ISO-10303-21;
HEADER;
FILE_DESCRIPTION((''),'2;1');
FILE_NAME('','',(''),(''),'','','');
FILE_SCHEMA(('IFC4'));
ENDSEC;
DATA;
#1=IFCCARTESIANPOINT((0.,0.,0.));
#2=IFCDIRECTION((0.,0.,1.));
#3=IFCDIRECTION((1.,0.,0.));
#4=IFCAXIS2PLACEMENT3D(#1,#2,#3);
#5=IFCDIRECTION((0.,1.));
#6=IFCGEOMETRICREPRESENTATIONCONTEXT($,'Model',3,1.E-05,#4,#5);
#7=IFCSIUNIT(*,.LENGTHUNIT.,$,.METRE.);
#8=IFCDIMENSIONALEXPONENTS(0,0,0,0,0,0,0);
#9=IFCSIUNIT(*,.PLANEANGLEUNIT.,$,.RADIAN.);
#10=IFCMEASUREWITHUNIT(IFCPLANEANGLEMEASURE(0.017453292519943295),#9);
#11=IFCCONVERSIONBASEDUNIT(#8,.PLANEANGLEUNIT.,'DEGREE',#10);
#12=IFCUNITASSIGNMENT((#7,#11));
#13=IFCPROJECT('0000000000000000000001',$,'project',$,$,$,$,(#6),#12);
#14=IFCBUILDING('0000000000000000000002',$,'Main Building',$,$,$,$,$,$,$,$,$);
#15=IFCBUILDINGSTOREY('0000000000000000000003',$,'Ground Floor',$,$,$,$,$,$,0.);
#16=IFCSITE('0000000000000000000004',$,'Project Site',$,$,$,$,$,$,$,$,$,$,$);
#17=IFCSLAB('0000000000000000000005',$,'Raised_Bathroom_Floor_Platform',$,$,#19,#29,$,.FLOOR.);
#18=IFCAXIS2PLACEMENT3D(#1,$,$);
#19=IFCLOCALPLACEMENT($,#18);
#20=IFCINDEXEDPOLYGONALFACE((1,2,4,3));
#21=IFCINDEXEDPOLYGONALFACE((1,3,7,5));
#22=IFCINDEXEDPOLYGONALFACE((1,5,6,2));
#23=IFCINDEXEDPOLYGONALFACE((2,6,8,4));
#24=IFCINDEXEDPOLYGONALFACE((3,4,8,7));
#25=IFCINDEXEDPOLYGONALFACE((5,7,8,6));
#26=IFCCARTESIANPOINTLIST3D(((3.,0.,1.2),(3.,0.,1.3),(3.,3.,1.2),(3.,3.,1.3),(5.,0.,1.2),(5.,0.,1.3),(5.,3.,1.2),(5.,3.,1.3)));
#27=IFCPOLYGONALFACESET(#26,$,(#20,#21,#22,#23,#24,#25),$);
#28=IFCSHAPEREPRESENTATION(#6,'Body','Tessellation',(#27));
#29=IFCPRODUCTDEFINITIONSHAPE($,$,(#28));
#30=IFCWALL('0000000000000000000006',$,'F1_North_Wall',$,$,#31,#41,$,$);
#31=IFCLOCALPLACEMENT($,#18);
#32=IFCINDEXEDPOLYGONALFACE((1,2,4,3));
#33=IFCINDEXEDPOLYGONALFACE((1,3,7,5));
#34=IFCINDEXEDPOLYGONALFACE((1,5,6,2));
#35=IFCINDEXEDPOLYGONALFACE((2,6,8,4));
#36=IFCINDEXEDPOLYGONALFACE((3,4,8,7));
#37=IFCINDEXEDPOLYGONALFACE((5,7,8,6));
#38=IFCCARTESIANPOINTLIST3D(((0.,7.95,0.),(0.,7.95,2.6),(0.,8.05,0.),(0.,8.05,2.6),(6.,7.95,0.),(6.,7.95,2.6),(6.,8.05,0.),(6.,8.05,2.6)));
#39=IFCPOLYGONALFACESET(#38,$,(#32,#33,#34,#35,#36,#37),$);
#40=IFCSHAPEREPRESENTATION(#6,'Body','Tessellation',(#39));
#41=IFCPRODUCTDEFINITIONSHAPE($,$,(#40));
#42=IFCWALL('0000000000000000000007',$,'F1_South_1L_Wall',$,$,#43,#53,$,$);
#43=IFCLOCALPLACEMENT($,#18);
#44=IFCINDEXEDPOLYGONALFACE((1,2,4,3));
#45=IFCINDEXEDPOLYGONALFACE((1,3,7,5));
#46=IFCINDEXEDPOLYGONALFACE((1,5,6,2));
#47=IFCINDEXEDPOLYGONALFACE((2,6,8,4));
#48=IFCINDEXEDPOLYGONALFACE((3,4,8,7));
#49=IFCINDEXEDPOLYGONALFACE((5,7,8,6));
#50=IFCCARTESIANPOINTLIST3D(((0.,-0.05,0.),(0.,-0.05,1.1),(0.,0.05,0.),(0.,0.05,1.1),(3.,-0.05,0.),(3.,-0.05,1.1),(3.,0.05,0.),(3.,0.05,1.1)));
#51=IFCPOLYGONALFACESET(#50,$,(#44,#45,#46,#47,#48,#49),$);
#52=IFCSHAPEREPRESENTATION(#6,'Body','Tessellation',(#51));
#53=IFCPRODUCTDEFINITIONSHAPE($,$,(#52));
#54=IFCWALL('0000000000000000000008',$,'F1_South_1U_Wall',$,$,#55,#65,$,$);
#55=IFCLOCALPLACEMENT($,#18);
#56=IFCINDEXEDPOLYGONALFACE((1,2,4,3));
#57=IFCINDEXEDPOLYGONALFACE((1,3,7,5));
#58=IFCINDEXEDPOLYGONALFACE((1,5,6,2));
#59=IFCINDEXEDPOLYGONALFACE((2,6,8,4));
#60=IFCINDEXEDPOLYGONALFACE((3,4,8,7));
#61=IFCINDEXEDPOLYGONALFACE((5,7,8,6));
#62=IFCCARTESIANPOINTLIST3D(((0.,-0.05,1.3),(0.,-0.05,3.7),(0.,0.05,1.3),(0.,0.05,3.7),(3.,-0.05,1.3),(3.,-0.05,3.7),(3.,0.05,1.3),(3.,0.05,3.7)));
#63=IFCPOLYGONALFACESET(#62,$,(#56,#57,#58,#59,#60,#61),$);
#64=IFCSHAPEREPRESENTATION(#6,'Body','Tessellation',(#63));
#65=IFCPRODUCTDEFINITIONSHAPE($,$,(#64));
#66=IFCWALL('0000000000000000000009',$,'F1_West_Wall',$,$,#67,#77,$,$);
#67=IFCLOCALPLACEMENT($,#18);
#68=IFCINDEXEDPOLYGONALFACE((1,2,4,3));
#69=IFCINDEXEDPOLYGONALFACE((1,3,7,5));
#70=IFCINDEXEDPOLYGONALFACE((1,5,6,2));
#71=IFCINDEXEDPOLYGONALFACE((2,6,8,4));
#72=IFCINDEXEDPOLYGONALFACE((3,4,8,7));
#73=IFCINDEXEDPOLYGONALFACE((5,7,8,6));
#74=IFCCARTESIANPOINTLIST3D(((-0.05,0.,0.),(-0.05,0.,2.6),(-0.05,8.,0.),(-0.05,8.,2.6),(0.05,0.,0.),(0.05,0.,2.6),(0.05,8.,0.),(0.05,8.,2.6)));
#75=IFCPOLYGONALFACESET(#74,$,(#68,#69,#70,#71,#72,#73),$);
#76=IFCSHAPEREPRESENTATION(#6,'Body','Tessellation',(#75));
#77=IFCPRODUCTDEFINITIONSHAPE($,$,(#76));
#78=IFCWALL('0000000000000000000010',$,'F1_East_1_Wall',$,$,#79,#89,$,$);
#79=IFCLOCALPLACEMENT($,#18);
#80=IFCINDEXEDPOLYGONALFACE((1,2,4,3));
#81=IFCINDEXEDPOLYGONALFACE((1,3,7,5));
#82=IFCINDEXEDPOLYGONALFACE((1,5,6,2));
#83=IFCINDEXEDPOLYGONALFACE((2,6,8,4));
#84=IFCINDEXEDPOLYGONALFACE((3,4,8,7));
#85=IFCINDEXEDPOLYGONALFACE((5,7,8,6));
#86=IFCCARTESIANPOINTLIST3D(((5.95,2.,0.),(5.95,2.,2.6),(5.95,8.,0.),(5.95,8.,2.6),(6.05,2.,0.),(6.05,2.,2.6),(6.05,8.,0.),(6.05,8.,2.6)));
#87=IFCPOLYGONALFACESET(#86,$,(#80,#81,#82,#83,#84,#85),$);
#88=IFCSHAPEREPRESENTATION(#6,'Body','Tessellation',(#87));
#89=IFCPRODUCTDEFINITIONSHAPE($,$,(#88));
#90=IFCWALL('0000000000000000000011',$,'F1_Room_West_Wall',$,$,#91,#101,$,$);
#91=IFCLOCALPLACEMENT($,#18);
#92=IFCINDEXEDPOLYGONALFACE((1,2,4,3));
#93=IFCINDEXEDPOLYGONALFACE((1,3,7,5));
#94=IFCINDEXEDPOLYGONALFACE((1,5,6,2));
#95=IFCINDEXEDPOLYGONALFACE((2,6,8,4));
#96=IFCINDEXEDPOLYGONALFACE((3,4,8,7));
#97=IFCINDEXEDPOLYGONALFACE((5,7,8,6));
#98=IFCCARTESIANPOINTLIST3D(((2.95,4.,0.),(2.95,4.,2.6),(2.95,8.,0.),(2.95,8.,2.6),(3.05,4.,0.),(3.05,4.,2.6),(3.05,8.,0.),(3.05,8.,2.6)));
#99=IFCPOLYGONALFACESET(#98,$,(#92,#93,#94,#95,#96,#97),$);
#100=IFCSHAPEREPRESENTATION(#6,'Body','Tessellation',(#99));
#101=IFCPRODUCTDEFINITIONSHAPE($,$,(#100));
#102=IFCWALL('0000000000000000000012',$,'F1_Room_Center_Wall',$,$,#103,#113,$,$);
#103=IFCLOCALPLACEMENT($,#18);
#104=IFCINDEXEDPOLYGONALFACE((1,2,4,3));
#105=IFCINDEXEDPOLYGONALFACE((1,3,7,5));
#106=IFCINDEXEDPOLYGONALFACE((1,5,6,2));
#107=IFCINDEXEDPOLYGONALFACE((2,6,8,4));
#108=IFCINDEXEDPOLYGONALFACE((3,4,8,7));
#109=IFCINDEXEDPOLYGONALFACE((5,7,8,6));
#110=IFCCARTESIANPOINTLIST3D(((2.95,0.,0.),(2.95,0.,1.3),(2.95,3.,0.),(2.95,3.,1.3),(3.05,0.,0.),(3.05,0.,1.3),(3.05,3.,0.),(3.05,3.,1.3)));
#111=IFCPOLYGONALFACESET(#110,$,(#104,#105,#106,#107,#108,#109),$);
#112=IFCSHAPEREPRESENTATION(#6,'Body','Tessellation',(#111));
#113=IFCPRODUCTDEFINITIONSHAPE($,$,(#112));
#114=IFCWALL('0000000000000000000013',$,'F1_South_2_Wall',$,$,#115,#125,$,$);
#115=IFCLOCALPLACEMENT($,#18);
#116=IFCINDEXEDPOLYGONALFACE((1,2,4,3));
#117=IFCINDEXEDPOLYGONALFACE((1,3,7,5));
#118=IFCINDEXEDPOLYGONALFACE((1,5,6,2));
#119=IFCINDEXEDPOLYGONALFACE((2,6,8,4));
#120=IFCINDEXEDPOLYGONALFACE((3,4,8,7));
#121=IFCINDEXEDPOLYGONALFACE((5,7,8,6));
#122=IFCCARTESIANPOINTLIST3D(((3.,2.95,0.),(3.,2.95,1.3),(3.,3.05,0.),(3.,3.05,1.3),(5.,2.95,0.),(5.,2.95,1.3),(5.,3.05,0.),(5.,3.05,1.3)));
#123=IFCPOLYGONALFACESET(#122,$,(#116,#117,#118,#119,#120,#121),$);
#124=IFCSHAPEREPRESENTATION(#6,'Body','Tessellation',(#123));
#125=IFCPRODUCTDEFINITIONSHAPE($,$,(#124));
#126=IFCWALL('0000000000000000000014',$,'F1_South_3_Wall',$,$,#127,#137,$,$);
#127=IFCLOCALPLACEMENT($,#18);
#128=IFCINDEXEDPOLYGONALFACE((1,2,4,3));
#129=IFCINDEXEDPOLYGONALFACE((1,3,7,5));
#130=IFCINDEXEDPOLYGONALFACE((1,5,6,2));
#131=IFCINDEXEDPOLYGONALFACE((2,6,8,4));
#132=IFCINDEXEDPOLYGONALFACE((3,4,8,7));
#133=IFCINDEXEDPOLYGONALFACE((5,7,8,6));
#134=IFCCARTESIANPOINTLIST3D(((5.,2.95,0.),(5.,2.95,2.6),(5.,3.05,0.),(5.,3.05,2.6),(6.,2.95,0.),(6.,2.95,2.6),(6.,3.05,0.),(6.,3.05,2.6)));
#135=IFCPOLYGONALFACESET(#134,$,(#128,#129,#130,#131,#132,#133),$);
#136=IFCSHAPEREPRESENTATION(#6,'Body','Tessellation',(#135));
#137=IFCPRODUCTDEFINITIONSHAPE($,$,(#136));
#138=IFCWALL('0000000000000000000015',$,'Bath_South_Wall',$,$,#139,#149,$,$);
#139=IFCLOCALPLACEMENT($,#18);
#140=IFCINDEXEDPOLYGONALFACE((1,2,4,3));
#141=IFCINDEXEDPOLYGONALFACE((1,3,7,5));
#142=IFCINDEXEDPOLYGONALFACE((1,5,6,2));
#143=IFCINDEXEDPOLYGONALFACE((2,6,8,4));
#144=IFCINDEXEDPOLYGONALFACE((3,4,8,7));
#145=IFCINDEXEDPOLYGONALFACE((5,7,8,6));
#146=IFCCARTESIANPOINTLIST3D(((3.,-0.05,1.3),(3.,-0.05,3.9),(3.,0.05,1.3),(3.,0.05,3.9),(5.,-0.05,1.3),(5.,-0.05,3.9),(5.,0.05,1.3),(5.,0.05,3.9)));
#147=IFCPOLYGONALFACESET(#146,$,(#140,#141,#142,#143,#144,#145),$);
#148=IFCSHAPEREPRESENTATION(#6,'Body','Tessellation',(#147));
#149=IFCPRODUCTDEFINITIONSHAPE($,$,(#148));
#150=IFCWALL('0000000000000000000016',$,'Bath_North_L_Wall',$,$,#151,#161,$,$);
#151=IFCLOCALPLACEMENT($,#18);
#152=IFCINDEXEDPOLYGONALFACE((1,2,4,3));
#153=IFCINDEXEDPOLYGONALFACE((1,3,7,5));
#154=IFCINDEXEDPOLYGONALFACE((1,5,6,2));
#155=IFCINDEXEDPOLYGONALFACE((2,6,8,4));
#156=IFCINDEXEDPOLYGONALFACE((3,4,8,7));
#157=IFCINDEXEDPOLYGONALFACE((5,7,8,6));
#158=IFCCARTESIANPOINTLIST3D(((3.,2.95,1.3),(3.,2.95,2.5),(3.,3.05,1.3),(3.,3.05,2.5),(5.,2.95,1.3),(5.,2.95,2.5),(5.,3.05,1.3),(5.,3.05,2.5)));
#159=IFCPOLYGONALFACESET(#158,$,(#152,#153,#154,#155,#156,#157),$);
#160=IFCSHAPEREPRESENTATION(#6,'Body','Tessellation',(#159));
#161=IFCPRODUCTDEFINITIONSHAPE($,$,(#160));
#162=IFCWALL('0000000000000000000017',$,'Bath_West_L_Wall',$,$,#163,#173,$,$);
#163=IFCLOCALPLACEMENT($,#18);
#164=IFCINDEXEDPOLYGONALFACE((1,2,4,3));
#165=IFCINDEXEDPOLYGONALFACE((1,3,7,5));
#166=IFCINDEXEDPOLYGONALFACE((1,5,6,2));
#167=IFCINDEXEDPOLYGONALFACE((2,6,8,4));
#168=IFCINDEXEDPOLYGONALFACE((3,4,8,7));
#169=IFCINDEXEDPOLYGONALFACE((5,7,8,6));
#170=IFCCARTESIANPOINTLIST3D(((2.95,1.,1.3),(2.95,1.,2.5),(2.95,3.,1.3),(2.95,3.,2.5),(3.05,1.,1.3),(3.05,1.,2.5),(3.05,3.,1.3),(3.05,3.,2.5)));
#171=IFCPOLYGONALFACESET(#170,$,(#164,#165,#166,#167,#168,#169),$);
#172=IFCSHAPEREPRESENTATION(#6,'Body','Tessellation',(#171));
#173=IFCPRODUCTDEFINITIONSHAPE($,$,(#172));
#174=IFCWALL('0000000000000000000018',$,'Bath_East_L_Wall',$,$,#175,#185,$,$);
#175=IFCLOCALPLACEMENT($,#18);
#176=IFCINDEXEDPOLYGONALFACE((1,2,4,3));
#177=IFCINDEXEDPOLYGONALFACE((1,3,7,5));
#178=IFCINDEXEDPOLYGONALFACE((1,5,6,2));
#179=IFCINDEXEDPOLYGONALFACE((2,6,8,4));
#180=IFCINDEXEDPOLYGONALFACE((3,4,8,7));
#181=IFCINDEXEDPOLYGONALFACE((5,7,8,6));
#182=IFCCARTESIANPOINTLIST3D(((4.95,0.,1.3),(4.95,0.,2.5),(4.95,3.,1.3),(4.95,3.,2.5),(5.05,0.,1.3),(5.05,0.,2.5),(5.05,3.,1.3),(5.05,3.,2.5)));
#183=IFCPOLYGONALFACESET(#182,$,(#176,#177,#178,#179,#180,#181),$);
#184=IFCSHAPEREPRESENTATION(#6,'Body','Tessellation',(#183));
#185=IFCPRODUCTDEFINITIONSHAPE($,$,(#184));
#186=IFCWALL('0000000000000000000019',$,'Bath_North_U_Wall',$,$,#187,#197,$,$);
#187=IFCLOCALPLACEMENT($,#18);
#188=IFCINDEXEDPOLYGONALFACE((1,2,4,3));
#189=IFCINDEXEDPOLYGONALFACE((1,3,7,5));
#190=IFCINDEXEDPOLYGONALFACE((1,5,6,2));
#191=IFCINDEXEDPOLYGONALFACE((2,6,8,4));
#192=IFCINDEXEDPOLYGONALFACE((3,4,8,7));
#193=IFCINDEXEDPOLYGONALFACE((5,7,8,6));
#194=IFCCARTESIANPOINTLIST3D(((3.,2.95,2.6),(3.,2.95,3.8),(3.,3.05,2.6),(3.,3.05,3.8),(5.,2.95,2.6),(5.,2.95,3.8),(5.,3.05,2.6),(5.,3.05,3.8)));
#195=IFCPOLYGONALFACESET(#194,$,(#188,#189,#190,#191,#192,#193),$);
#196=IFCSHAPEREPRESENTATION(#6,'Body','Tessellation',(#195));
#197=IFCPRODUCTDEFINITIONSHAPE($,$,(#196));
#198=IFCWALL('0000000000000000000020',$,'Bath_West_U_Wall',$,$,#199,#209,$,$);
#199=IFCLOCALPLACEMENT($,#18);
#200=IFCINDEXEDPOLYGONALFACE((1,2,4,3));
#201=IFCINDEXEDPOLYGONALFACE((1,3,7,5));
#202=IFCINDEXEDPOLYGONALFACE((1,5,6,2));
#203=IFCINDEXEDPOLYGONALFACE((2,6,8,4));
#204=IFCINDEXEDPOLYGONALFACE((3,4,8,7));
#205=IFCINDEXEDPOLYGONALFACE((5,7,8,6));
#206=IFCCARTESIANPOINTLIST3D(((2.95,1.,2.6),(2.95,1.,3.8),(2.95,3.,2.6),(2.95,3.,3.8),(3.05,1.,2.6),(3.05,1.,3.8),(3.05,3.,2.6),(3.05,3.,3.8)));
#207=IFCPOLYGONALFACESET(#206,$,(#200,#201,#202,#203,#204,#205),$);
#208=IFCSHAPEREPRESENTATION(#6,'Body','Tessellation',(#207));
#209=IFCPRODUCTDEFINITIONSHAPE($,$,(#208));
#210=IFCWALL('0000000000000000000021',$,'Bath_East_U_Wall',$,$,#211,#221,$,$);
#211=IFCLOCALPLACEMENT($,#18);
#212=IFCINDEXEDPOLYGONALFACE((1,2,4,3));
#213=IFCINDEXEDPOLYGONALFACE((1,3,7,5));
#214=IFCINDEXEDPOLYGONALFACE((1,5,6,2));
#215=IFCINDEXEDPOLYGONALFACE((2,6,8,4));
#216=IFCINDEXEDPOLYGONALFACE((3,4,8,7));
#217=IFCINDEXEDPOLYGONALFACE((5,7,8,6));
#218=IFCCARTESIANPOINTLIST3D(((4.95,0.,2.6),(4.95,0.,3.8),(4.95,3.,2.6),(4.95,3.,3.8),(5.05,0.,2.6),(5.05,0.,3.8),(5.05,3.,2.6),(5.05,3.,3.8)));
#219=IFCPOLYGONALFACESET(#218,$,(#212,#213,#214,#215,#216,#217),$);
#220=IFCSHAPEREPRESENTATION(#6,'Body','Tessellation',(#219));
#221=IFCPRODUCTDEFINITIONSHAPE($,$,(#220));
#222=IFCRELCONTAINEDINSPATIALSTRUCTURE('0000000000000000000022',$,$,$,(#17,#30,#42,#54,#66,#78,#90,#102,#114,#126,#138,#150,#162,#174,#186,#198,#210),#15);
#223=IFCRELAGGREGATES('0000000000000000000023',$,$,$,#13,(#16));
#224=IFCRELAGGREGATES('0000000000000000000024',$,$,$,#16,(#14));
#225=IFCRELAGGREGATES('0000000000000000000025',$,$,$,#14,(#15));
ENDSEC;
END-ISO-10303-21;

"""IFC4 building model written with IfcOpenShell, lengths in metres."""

from ifc_helpers import new_model, entity, si_unit, converted_unit, direction, frame, frame_2d, origin, origin_with_axes, place, context, project, spatial, polyline, rectangle, outline, extrude, element, save


model = new_model("IFC4")

# Units and contexts
model_context = context("Model", 3, precision=1e-05, world=origin_with_axes(), true_north=direction((0.0, 1.0)))
ifc_project = project(units=[si_unit("LENGTHUNIT", "METRE"), converted_unit("PLANEANGLEUNIT", "DEGREE", entity("IfcPlaneAngleMeasure", 0.017453292519943295), si_unit("PLANEANGLEUNIT", "RADIAN"), dimensions=[0, 0, 0, 0, 0, 0, 0])], contexts=[model_context])

# Site, building, storey
site = spatial("IfcSite", under=ifc_project, Name="Project Site")
building = spatial("IfcBuilding", under=site, Name="Main Building")
storey = spatial("IfcBuildingStorey", under=building, Name="Ground Floor", Elevation=0.0)

# Slab
slab_1_placement = place(None, frame((0.0, 0.0, 1.2), z_axis=(0.0, 0.0, 1.0), x_axis=(1.0, 0.0, 0.0)))
element("IfcSlab", 1, at=slab_1_placement, inside=storey, Name="Raised_Bathroom_Floor_Platform", PredefinedType="FLOOR", context=model_context, shape_type="SweptSolid", body=[
    extrude(outline(polyline([(3.0, 0.0), (5.0, 0.0), (5.0, 3.0), (3.0, 3.0), (3.0, 0.0)])), origin(), (0.0, 0.0, 1.0), 0.1),
])

# Walls
wall_1_placement = place(None, frame((0.0, 8.0, 0.0), z_axis=(0.0, 0.0, 1.0), x_axis=(1.0, 0.0, 0.0)))
element("IfcWall", 2, at=wall_1_placement, inside=storey, Name="F1_North_Wall", context=model_context, shape_type="SweptSolid", body=[
    extrude(rectangle(XDim=6.0, YDim=0.1, at=frame_2d((3.0, 0.0))), origin(), (0.0, 0.0, 1.0), 2.6),
])
wall_2_placement = place(None, origin_with_axes())
element("IfcWall", 3, at=wall_2_placement, inside=storey, Name="F1_South_1L_Wall", context=model_context, shape_type="SweptSolid", body=[
    extrude(rectangle(XDim=3.0, YDim=0.1, at=frame_2d((1.5, 0.0))), origin(), (0.0, 0.0, 1.0), 1.1),
])
wall_3_placement = place(None, frame((0.0, 0.0, 1.3), z_axis=(0.0, 0.0, 1.0), x_axis=(1.0, 0.0, 0.0)))
element("IfcWall", 4, at=wall_3_placement, inside=storey, Name="F1_South_1U_Wall", context=model_context, shape_type="SweptSolid", body=[
    extrude(rectangle(XDim=3.0, YDim=0.1, at=frame_2d((1.5, 0.0))), origin(), (0.0, 0.0, 1.0), 2.4),
])
wall_4_placement = place(None, frame((0.0, 0.0, 0.0), z_axis=(0.0, 0.0, 1.0), x_axis=(0.0, 1.0, 0.0)))
element("IfcWall", 5, at=wall_4_placement, inside=storey, Name="F1_West_Wall", context=model_context, shape_type="SweptSolid", body=[
    extrude(rectangle(XDim=8.0, YDim=0.1, at=frame_2d((4.0, 0.0))), origin(), (0.0, 0.0, 1.0), 2.6),
])
wall_5_placement = place(None, frame((6.0, 2.0, 0.0), z_axis=(0.0, 0.0, 1.0), x_axis=(0.0, 1.0, 0.0)))
element("IfcWall", 6, at=wall_5_placement, inside=storey, Name="F1_East_1_Wall", context=model_context, shape_type="SweptSolid", body=[
    extrude(rectangle(XDim=6.0, YDim=0.1, at=frame_2d((3.0, 0.0))), origin(), (0.0, 0.0, 1.0), 2.6),
])
wall_6_placement = place(None, frame((3.0, 4.0, 0.0), z_axis=(0.0, 0.0, 1.0), x_axis=(0.0, 1.0, 0.0)))
element("IfcWall", 7, at=wall_6_placement, inside=storey, Name="F1_Room_West_Wall", context=model_context, shape_type="SweptSolid", body=[
    extrude(rectangle(XDim=4.0, YDim=0.1, at=frame_2d((2.0, 0.0))), origin(), (0.0, 0.0, 1.0), 2.6),
])
wall_7_placement = place(None, frame((3.0, 0.0, 0.0), z_axis=(0.0, 0.0, 1.0), x_axis=(0.0, 1.0, 0.0)))
element("IfcWall", 8, at=wall_7_placement, inside=storey, Name="F1_Room_Center_Wall", context=model_context, shape_type="SweptSolid", body=[
    extrude(rectangle(XDim=3.0, YDim=0.1, at=frame_2d((1.5, 0.0))), origin(), (0.0, 0.0, 1.0), 1.3),
])
wall_8_placement = place(None, frame((3.0, 3.0, 0.0), z_axis=(0.0, 0.0, 1.0), x_axis=(1.0, 0.0, 0.0)))
element("IfcWall", 9, at=wall_8_placement, inside=storey, Name="F1_South_2_Wall", context=model_context, shape_type="SweptSolid", body=[
    extrude(rectangle(XDim=2.0, YDim=0.1, at=frame_2d((1.0, 0.0))), origin(), (0.0, 0.0, 1.0), 1.3),
])
wall_9_placement = place(None, frame((5.0, 3.0, 0.0), z_axis=(0.0, 0.0, 1.0), x_axis=(1.0, 0.0, 0.0)))
element("IfcWall", 10, at=wall_9_placement, inside=storey, Name="F1_South_3_Wall", context=model_context, shape_type="SweptSolid", body=[
    extrude(rectangle(XDim=1.0, YDim=0.1, at=frame_2d((0.5, 0.0))), origin(), (0.0, 0.0, 1.0), 2.6),
])
wall_10_placement = place(None, frame((3.0, 0.0, 1.3), z_axis=(0.0, 0.0, 1.0), x_axis=(1.0, 0.0, 0.0)))
element("IfcWall", 11, at=wall_10_placement, inside=storey, Name="Bath_South_Wall", context=model_context, shape_type="SweptSolid", body=[
    extrude(rectangle(XDim=2.0, YDim=0.1, at=frame_2d((1.0, 0.0))), origin(), (0.0, 0.0, 1.0), 2.6),
])
for number, where, z_axis, x_axis, name in (
    (12, (3.0, 3.0, 1.3), (0.0, 0.0, 1.0), (1.0, 0.0, 0.0), "Bath_North_L_Wall"),
    (13, (3.0, 1.0, 1.3), (0.0, 0.0, 1.0), (0.0, 1.0, 0.0), "Bath_West_L_Wall"),
):
    element("IfcWall", number, at=place(None, frame(where, z_axis=z_axis, x_axis=x_axis)), inside=storey, Name=name, context=model_context, shape_type="SweptSolid", body=[
        extrude(rectangle(XDim=2.0, YDim=0.1, at=frame_2d((1.0, 0.0))), origin(), (0.0, 0.0, 1.0), 1.2),
    ])
wall_11_placement = place(None, frame((5.0, 0.0, 1.3), z_axis=(0.0, 0.0, 1.0), x_axis=(0.0, 1.0, 0.0)))
element("IfcWall", 14, at=wall_11_placement, inside=storey, Name="Bath_East_L_Wall", context=model_context, shape_type="SweptSolid", body=[
    extrude(rectangle(XDim=3.0, YDim=0.1, at=frame_2d((1.5, 0.0))), origin(), (0.0, 0.0, 1.0), 1.2),
])
for number, where, z_axis, x_axis, name in (
    (15, (3.0, 3.0, 2.6), (0.0, 0.0, 1.0), (1.0, 0.0, 0.0), "Bath_North_U_Wall"),
    (16, (3.0, 1.0, 2.6), (0.0, 0.0, 1.0), (0.0, 1.0, 0.0), "Bath_West_U_Wall"),
):
    element("IfcWall", number, at=place(None, frame(where, z_axis=z_axis, x_axis=x_axis)), inside=storey, Name=name, context=model_context, shape_type="SweptSolid", body=[
        extrude(rectangle(XDim=2.0, YDim=0.1, at=frame_2d((1.0, 0.0))), origin(), (0.0, 0.0, 1.0), 1.2),
    ])
wall_12_placement = place(None, frame((5.0, 0.0, 2.6), z_axis=(0.0, 0.0, 1.0), x_axis=(0.0, 1.0, 0.0)))
element("IfcWall", 17, at=wall_12_placement, inside=storey, Name="Bath_East_U_Wall", context=model_context, shape_type="SweptSolid", body=[
    extrude(rectangle(XDim=3.0, YDim=0.1, at=frame_2d((1.5, 0.0))), origin(), (0.0, 0.0, 1.0), 1.2),
])

save(model, "model.ifc")
